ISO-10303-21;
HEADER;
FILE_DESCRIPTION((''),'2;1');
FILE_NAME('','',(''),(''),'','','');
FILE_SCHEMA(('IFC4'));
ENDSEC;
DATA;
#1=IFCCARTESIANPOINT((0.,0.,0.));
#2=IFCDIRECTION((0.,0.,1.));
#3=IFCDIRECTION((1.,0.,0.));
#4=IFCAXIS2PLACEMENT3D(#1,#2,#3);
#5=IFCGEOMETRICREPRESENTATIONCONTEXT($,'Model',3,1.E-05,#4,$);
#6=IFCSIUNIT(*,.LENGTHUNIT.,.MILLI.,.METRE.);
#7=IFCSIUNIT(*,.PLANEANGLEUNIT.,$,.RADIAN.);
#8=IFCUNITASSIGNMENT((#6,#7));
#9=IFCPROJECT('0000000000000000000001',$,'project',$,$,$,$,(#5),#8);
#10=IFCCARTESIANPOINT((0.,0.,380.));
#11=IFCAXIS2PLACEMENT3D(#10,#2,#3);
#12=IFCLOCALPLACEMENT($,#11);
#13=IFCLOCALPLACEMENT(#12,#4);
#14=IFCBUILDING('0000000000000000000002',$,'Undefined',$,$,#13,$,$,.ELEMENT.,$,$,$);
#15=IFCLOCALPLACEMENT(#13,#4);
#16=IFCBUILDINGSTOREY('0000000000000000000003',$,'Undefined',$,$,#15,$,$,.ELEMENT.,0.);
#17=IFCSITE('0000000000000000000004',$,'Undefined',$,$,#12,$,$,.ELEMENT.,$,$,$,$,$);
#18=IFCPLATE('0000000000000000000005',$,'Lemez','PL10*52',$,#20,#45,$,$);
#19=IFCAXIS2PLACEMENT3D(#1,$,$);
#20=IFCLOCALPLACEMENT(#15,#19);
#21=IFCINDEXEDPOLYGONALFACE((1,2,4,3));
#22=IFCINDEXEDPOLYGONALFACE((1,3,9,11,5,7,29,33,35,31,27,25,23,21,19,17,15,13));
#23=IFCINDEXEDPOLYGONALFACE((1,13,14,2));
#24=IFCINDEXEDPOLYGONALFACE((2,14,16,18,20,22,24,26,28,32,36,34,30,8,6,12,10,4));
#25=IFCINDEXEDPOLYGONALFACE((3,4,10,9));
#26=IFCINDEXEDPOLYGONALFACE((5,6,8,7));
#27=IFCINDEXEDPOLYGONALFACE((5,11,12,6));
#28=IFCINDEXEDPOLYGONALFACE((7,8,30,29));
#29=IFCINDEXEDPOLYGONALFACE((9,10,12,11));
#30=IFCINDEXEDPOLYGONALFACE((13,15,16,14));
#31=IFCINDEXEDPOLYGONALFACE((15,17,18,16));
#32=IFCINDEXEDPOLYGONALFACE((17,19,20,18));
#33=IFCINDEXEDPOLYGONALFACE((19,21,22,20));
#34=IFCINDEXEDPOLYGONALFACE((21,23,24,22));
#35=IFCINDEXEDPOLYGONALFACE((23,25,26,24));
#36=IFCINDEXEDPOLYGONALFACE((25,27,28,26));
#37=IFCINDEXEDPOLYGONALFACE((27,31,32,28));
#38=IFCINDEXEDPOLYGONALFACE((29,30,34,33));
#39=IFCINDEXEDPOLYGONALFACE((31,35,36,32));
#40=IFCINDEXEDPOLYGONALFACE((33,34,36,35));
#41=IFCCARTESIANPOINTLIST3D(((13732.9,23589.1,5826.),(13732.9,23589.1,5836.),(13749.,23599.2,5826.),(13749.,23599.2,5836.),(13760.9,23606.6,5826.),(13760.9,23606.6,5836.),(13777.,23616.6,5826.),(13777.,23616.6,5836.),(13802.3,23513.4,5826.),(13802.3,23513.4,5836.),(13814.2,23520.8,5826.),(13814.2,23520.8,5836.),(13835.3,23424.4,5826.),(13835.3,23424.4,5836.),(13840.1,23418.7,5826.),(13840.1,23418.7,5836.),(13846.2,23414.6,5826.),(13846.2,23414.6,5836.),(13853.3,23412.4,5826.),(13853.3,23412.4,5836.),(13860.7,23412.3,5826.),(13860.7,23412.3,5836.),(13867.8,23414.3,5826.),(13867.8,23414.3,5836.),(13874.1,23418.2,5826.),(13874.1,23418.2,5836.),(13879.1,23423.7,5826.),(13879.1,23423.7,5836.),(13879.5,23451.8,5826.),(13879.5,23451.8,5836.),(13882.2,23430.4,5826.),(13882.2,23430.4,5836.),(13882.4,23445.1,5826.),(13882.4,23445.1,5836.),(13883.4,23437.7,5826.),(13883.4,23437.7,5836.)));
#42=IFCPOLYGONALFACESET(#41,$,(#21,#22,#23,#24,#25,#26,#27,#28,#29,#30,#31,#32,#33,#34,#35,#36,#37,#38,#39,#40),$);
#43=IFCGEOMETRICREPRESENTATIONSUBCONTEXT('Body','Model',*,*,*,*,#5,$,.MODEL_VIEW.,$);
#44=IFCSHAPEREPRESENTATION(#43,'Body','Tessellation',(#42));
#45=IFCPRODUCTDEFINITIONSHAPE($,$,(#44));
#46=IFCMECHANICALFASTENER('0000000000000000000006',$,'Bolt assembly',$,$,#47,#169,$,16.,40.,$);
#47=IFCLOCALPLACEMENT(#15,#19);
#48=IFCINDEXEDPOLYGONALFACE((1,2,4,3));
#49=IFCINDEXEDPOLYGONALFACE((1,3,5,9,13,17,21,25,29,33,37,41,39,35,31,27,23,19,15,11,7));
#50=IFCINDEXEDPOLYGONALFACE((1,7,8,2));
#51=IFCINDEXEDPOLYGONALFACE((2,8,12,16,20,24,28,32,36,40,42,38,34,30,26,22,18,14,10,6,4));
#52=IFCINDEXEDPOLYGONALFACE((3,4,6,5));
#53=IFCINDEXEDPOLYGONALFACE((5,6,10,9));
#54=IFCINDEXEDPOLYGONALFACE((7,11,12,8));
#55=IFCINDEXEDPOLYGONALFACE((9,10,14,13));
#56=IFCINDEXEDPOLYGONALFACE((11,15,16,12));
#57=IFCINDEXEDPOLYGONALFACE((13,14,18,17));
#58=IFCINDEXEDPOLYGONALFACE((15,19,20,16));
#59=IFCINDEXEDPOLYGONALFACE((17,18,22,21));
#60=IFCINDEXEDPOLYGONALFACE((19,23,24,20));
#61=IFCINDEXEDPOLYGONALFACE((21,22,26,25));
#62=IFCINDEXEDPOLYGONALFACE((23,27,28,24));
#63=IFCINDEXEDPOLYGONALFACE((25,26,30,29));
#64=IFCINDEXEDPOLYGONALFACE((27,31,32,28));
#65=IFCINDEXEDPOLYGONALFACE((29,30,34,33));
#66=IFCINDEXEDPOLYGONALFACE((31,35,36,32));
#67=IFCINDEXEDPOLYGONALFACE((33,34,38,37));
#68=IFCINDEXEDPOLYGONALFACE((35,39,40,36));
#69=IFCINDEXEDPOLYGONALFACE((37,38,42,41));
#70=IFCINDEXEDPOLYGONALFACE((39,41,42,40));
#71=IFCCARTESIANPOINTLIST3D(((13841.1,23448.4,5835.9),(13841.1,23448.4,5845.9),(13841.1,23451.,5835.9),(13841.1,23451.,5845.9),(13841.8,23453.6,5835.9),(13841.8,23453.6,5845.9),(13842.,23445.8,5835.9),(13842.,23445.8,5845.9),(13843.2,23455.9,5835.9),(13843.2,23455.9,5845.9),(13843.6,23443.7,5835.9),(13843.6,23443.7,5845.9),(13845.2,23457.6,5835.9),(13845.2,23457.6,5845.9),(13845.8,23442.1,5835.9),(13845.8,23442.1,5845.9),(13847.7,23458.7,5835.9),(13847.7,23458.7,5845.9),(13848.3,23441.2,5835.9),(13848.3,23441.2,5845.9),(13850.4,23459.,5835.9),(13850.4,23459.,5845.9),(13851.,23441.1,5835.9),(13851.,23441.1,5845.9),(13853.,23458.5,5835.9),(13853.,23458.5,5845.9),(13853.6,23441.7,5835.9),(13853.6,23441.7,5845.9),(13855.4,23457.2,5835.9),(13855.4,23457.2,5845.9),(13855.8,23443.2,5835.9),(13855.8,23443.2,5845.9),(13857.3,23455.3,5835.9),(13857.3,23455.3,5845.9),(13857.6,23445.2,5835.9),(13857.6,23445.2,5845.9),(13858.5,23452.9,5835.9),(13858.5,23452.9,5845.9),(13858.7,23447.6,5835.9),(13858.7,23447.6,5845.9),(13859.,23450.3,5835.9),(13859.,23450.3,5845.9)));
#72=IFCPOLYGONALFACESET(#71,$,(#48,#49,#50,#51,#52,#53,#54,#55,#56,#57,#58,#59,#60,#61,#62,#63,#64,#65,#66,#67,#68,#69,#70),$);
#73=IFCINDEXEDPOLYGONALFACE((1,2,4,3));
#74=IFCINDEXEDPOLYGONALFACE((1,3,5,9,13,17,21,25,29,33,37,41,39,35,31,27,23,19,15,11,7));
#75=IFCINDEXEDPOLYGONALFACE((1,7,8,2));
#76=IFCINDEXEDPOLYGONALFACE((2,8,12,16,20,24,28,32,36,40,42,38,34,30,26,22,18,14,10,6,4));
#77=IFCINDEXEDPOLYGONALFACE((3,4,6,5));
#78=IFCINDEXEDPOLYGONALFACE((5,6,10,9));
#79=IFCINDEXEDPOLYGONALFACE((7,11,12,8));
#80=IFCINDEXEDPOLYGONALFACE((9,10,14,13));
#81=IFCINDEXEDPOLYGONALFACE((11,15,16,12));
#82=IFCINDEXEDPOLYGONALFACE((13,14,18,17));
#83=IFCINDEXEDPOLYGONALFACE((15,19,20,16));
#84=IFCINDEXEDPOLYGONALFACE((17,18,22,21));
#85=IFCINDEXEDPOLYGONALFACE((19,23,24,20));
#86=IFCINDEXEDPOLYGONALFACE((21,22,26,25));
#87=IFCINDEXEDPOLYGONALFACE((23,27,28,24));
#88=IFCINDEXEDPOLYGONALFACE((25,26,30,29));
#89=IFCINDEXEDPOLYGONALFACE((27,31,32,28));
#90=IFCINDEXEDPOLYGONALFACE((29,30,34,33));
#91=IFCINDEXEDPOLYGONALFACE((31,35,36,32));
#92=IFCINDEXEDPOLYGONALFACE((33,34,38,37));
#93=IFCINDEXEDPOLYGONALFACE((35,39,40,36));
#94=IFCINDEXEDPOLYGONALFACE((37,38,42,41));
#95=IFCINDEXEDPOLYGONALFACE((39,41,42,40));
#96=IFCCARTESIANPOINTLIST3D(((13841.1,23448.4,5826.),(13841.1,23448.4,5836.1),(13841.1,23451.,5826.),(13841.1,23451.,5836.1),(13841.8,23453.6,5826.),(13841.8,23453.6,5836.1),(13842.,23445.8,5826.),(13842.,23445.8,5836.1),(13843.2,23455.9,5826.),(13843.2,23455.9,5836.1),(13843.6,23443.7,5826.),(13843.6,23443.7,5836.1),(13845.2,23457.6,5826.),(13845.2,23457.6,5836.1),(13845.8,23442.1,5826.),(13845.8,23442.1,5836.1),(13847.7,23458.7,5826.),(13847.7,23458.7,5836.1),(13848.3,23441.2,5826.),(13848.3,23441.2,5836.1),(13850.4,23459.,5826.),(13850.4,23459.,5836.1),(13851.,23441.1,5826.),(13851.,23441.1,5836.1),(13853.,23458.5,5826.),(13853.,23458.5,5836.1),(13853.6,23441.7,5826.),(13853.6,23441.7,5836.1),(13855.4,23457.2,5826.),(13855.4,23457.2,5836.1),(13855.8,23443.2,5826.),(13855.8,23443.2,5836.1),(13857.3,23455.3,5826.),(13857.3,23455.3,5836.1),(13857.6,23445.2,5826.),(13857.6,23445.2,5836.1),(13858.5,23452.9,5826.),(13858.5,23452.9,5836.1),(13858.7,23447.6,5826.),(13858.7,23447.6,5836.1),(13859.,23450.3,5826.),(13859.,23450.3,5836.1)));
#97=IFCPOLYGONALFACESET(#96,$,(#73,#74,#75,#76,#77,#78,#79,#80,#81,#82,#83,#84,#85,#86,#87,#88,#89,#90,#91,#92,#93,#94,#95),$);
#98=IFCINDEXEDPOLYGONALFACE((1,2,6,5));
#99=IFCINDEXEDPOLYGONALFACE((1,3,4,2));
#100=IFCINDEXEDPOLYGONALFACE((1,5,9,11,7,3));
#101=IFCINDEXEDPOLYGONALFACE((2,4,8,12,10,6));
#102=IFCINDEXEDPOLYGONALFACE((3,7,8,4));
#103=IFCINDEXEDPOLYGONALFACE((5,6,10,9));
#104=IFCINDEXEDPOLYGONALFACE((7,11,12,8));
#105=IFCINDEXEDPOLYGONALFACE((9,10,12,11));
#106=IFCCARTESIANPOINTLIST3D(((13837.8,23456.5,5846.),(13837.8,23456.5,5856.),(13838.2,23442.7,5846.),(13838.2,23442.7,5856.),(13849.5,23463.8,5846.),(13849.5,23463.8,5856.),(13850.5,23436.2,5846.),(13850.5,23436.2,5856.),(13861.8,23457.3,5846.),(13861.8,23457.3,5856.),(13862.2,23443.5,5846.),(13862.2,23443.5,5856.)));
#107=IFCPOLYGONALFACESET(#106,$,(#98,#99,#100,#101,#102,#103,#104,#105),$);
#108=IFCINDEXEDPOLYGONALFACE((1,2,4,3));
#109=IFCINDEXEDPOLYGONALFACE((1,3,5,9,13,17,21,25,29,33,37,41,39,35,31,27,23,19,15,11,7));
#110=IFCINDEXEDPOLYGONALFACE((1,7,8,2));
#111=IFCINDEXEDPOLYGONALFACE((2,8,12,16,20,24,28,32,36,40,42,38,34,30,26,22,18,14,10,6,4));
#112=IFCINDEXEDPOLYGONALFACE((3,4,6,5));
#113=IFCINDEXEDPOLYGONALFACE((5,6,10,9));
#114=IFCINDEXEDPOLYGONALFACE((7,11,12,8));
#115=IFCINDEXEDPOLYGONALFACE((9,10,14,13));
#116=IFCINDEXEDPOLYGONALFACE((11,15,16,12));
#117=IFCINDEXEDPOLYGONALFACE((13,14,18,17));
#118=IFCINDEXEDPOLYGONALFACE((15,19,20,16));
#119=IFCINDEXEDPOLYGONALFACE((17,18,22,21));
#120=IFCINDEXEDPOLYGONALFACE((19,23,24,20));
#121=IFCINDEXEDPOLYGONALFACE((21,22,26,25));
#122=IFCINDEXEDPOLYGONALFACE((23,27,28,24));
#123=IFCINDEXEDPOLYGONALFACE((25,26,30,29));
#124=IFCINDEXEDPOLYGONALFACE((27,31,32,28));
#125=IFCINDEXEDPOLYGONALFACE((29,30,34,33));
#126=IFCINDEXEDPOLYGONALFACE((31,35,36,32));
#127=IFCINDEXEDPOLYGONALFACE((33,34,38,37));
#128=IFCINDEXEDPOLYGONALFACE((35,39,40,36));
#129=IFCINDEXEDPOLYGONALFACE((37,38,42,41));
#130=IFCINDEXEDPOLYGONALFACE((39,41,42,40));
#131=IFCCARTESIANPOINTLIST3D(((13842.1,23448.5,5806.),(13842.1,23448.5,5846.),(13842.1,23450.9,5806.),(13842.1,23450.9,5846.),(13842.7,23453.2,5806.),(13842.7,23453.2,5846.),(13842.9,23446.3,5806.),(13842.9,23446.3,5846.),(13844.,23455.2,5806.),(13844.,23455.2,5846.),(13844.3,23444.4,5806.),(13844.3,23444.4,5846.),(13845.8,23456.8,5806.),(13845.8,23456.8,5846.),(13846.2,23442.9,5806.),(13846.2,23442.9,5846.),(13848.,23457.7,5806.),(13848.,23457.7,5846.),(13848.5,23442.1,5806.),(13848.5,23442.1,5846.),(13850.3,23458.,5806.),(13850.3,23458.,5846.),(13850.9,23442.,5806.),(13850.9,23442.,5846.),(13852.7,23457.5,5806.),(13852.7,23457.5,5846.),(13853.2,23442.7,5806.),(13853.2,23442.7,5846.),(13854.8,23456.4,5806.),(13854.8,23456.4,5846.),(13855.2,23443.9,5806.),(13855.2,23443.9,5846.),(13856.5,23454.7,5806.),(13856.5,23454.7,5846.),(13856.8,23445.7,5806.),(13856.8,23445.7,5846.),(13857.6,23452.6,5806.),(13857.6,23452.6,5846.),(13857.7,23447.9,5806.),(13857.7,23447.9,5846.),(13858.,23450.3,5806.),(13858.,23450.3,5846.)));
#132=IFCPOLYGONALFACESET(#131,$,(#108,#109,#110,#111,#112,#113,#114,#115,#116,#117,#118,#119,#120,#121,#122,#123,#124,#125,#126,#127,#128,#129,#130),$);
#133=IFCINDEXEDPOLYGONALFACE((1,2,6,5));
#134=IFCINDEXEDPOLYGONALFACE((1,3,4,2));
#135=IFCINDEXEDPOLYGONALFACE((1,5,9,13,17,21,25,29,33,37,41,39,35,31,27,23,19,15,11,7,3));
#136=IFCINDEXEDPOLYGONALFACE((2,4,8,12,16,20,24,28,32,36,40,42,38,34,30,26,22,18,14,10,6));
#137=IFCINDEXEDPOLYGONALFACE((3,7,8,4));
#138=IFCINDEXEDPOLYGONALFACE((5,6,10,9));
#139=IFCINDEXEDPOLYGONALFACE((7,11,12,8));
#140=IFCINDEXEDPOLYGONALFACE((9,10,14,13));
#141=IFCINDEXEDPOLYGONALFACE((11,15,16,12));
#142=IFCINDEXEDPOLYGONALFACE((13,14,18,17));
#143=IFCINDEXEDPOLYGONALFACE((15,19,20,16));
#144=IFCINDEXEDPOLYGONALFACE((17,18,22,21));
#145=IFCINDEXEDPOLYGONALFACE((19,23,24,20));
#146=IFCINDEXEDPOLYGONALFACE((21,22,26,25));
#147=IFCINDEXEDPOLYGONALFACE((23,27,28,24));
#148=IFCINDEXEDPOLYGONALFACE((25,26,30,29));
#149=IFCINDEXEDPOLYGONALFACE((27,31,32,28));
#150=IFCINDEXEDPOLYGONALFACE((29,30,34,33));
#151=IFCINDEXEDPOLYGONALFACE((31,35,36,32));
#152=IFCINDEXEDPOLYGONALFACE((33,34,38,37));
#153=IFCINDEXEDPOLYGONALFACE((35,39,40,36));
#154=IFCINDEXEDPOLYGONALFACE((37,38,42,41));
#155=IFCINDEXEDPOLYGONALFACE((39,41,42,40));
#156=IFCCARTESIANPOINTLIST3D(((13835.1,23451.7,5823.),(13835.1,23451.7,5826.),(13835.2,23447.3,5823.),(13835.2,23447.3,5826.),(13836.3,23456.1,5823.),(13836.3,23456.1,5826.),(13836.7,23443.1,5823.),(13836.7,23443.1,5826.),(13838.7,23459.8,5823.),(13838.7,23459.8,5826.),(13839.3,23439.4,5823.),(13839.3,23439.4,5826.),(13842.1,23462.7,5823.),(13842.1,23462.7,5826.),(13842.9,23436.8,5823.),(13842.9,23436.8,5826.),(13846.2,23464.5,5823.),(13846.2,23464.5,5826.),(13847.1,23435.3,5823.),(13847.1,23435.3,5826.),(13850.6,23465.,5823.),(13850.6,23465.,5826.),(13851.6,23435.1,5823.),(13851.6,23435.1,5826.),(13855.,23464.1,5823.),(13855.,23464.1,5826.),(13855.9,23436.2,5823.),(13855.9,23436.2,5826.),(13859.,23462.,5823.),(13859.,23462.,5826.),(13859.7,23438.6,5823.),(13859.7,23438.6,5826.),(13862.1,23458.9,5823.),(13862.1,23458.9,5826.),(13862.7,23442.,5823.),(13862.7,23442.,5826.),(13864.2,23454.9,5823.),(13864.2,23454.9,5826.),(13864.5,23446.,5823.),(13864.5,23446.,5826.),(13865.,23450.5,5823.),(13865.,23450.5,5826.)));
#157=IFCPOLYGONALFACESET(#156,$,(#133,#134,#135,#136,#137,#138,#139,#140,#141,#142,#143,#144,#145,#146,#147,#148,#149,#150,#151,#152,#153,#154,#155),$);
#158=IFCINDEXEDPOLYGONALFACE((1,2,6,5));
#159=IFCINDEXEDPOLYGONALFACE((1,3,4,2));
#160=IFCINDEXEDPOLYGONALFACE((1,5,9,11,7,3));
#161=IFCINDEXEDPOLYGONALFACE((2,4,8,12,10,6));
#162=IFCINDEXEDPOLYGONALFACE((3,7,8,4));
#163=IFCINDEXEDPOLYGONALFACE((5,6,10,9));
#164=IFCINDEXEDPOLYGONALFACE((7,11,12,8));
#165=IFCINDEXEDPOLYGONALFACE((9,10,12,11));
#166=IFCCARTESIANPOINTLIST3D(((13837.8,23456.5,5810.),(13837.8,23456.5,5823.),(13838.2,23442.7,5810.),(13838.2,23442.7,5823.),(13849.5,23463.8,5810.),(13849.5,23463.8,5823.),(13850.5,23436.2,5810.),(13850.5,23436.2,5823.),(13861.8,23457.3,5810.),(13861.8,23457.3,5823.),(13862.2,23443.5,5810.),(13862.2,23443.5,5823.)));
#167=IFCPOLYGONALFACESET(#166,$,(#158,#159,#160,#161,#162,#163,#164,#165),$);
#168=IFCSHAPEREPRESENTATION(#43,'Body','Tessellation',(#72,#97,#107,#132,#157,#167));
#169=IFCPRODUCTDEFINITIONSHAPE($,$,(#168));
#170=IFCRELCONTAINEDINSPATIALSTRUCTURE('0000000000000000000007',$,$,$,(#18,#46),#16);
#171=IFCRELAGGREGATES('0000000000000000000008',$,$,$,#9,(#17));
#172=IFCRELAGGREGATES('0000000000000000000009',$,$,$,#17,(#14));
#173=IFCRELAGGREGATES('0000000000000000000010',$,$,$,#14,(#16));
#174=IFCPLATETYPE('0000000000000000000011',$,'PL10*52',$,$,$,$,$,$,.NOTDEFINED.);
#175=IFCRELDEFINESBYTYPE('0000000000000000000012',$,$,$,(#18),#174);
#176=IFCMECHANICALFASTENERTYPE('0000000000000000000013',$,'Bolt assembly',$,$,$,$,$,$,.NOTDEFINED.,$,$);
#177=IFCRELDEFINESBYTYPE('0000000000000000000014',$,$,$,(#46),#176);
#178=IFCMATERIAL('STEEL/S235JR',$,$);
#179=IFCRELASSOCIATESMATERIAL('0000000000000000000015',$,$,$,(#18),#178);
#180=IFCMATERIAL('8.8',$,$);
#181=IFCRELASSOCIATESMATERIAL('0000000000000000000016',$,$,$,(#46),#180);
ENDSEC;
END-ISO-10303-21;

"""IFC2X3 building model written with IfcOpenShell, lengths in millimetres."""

from ifc_helpers import new_model, si_unit, frame, frame_2d, origin_with_axes, origin_2d_with_axis, place, context, subcontext, project, spatial, polyline, circle_curve, parameter, trimmed, segment, composite_curve, rectangle, circle, outline, extrude, boolean, source, transform, mapped, material, type_object, element, save


model = new_model("IFC2X3")

# Units and contexts
model_context = context("Model", 3, precision=1e-05, world=origin_with_axes())
body_context = subcontext(model_context, "Body", "Model", "MODEL_VIEW")
ifc_project = project(units=[si_unit("LENGTHUNIT", "METRE", prefix="MILLI"), si_unit("PLANEANGLEUNIT", "RADIAN")], contexts=[model_context])

# Site, building, storey
site_placement = place(None, frame((0.0, 0.0, 380.0), z_axis=(0.0, 0.0, 1.0), x_axis=(1.0, 0.0, 0.0)))
site = spatial("IfcSite", under=ifc_project, at=site_placement, Name="Undefined", CompositionType="ELEMENT")
building_placement = place(site_placement, origin_with_axes())
building = spatial("IfcBuilding", under=site, at=building_placement, Name="Undefined", CompositionType="ELEMENT")
storey_placement = place(building_placement, origin_with_axes())
storey = spatial("IfcBuildingStorey", under=building, at=storey_placement, Name="Undefined", CompositionType="ELEMENT", Elevation=0.0)

# Shared definitions
ifc_material_1 = material(Name="STEEL/S235JR")

# Plate
plate_type_1 = type_object("IfcPlateType", Name="PL10*52", PredefinedType="NOTDEFINED")
for number, where, z_axis, x_axis, name in (
    (1, (13849.0, 23402.3, 5831.0), (0.0, 0.0, 1.0), (0.849199, 0.528073, 0.0), "Lemez"),
):
    element("IfcPlate", number, at=place(storey_placement, frame(where, z_axis=z_axis, x_axis=x_axis)), inside=storey, type_object=plate_type_1, material=ifc_material_1, Name=name, Description="PL10*52", context=body_context, shape_type="CSG", body=[
        boolean("DIFFERENCE", extrude(outline(composite_curve([segment(trimmed(circle_curve(frame_2d((26.0, 26.0), x_axis=(-1.0, 0.0)), 26.0), [parameter(0.0)], [parameter(1.570796)], True, "PARAMETER"), True, "CONTINUOUS"), segment(trimmed(circle_curve(frame_2d((26.0, 26.0), x_axis=(0.0, -1.0)), 26.0), [parameter(0.0)], [parameter(1.570796)], True, "PARAMETER"), True, "CONTINUOUS"), segment(polyline([(52.0, 26.0), (52.0, 220.0), (0.0, 220.0), (0.0, 26.0)]), True, "CONTINUOUS")], self_intersect=True)), frame((0.0, 0.0, -5.0), z_axis=(0.0, 0.0, 1.0), x_axis=(1.0, 0.0, 0.0)), (0.0, 0.0, 1.0), 10.0), extrude(rectangle(XDim=14.0, YDim=14.0, at=origin_2d_with_axis()), frame((26.0, 320.0, 0.0), z_axis=(0.0, -1.0, 0.0), x_axis=(1.0, 0.0, 0.0)), (0.0, 0.0, 1.0), 201.0)),
    ])

# Mechanical fastener
ifc_material_2 = material(Name="8.8")
mechanical_fastener_type = type_object("IfcMechanicalFastenerType", Name="Bolt assembly")
shared_shape_1 = source(origin_with_axes(), body_context, "Body", "SweptSolid", [
    extrude(circle(Radius=9.0, at=origin_2d_with_axis()), frame((0.0, -14.9, 0.0), z_axis=(0.0, 1.0, 0.0), x_axis=(1.0, 0.0, 0.0)), (0.0, 0.0, 1.0), 10.0),
    extrude(circle(Radius=9.0, at=origin_2d_with_axis()), frame((0.0, -5.1, 0.0), z_axis=(0.0, 1.0, 0.0), x_axis=(1.0, 0.0, 0.0)), (0.0, 0.0, 1.0), 10.1),
    extrude(outline(polyline([(12.0, -6.9), (12.0, 6.9), (0.0, 13.9), (-12.0, 6.9), (-12.0, -6.9), (0.0, -13.9), (12.0, -6.9)])), frame((0.0, -25.0, 0.0), z_axis=(0.0, 1.0, 0.0), x_axis=(1.0, 0.0, 0.0)), (0.0, 0.0, 1.0), 10.0),
    extrude(circle(Radius=8.0, at=origin_2d_with_axis()), frame((0.0, -15.0, 0.0), z_axis=(0.0, 1.0, 0.0), x_axis=(1.0, 0.0, 0.0)), (0.0, 0.0, 1.0), 40.0),
    extrude(circle(Radius=15.0, at=origin_2d_with_axis()), frame((0.0, 5.0, 0.0), z_axis=(0.0, 1.0, 0.0), x_axis=(1.0, 0.0, 0.0)), (0.0, 0.0, 1.0), 3.0),
    extrude(outline(polyline([(12.0, -6.9), (12.0, 6.9), (0.0, 13.9), (-12.0, 6.9), (-12.0, -6.9), (0.0, -13.9), (12.0, -6.9)])), frame((0.0, 8.0, 0.0), z_axis=(0.0, 1.0, 0.0), x_axis=(1.0, 0.0, 0.0)), (0.0, 0.0, 1.0), 13.0),
])
mechanical_fastener_1_placement = place(storey_placement, frame((13850.0, 23450.0, 5831.0), z_axis=(-0.849199, -0.528073, 0.0), x_axis=(-0.528073, 0.849199, 0.0)))
element("IfcMechanicalFastener", 2, at=mechanical_fastener_1_placement, inside=storey, type_object=mechanical_fastener_type, material=ifc_material_2, Name="Bolt assembly", NominalDiameter=16.0, NominalLength=40.0, context=body_context, shape_type="MappedRepresentation", body=[
    mapped(shared_shape_1, transform((0.0, 0.0, 0.0))),
])

save(model, "model.ifc")
